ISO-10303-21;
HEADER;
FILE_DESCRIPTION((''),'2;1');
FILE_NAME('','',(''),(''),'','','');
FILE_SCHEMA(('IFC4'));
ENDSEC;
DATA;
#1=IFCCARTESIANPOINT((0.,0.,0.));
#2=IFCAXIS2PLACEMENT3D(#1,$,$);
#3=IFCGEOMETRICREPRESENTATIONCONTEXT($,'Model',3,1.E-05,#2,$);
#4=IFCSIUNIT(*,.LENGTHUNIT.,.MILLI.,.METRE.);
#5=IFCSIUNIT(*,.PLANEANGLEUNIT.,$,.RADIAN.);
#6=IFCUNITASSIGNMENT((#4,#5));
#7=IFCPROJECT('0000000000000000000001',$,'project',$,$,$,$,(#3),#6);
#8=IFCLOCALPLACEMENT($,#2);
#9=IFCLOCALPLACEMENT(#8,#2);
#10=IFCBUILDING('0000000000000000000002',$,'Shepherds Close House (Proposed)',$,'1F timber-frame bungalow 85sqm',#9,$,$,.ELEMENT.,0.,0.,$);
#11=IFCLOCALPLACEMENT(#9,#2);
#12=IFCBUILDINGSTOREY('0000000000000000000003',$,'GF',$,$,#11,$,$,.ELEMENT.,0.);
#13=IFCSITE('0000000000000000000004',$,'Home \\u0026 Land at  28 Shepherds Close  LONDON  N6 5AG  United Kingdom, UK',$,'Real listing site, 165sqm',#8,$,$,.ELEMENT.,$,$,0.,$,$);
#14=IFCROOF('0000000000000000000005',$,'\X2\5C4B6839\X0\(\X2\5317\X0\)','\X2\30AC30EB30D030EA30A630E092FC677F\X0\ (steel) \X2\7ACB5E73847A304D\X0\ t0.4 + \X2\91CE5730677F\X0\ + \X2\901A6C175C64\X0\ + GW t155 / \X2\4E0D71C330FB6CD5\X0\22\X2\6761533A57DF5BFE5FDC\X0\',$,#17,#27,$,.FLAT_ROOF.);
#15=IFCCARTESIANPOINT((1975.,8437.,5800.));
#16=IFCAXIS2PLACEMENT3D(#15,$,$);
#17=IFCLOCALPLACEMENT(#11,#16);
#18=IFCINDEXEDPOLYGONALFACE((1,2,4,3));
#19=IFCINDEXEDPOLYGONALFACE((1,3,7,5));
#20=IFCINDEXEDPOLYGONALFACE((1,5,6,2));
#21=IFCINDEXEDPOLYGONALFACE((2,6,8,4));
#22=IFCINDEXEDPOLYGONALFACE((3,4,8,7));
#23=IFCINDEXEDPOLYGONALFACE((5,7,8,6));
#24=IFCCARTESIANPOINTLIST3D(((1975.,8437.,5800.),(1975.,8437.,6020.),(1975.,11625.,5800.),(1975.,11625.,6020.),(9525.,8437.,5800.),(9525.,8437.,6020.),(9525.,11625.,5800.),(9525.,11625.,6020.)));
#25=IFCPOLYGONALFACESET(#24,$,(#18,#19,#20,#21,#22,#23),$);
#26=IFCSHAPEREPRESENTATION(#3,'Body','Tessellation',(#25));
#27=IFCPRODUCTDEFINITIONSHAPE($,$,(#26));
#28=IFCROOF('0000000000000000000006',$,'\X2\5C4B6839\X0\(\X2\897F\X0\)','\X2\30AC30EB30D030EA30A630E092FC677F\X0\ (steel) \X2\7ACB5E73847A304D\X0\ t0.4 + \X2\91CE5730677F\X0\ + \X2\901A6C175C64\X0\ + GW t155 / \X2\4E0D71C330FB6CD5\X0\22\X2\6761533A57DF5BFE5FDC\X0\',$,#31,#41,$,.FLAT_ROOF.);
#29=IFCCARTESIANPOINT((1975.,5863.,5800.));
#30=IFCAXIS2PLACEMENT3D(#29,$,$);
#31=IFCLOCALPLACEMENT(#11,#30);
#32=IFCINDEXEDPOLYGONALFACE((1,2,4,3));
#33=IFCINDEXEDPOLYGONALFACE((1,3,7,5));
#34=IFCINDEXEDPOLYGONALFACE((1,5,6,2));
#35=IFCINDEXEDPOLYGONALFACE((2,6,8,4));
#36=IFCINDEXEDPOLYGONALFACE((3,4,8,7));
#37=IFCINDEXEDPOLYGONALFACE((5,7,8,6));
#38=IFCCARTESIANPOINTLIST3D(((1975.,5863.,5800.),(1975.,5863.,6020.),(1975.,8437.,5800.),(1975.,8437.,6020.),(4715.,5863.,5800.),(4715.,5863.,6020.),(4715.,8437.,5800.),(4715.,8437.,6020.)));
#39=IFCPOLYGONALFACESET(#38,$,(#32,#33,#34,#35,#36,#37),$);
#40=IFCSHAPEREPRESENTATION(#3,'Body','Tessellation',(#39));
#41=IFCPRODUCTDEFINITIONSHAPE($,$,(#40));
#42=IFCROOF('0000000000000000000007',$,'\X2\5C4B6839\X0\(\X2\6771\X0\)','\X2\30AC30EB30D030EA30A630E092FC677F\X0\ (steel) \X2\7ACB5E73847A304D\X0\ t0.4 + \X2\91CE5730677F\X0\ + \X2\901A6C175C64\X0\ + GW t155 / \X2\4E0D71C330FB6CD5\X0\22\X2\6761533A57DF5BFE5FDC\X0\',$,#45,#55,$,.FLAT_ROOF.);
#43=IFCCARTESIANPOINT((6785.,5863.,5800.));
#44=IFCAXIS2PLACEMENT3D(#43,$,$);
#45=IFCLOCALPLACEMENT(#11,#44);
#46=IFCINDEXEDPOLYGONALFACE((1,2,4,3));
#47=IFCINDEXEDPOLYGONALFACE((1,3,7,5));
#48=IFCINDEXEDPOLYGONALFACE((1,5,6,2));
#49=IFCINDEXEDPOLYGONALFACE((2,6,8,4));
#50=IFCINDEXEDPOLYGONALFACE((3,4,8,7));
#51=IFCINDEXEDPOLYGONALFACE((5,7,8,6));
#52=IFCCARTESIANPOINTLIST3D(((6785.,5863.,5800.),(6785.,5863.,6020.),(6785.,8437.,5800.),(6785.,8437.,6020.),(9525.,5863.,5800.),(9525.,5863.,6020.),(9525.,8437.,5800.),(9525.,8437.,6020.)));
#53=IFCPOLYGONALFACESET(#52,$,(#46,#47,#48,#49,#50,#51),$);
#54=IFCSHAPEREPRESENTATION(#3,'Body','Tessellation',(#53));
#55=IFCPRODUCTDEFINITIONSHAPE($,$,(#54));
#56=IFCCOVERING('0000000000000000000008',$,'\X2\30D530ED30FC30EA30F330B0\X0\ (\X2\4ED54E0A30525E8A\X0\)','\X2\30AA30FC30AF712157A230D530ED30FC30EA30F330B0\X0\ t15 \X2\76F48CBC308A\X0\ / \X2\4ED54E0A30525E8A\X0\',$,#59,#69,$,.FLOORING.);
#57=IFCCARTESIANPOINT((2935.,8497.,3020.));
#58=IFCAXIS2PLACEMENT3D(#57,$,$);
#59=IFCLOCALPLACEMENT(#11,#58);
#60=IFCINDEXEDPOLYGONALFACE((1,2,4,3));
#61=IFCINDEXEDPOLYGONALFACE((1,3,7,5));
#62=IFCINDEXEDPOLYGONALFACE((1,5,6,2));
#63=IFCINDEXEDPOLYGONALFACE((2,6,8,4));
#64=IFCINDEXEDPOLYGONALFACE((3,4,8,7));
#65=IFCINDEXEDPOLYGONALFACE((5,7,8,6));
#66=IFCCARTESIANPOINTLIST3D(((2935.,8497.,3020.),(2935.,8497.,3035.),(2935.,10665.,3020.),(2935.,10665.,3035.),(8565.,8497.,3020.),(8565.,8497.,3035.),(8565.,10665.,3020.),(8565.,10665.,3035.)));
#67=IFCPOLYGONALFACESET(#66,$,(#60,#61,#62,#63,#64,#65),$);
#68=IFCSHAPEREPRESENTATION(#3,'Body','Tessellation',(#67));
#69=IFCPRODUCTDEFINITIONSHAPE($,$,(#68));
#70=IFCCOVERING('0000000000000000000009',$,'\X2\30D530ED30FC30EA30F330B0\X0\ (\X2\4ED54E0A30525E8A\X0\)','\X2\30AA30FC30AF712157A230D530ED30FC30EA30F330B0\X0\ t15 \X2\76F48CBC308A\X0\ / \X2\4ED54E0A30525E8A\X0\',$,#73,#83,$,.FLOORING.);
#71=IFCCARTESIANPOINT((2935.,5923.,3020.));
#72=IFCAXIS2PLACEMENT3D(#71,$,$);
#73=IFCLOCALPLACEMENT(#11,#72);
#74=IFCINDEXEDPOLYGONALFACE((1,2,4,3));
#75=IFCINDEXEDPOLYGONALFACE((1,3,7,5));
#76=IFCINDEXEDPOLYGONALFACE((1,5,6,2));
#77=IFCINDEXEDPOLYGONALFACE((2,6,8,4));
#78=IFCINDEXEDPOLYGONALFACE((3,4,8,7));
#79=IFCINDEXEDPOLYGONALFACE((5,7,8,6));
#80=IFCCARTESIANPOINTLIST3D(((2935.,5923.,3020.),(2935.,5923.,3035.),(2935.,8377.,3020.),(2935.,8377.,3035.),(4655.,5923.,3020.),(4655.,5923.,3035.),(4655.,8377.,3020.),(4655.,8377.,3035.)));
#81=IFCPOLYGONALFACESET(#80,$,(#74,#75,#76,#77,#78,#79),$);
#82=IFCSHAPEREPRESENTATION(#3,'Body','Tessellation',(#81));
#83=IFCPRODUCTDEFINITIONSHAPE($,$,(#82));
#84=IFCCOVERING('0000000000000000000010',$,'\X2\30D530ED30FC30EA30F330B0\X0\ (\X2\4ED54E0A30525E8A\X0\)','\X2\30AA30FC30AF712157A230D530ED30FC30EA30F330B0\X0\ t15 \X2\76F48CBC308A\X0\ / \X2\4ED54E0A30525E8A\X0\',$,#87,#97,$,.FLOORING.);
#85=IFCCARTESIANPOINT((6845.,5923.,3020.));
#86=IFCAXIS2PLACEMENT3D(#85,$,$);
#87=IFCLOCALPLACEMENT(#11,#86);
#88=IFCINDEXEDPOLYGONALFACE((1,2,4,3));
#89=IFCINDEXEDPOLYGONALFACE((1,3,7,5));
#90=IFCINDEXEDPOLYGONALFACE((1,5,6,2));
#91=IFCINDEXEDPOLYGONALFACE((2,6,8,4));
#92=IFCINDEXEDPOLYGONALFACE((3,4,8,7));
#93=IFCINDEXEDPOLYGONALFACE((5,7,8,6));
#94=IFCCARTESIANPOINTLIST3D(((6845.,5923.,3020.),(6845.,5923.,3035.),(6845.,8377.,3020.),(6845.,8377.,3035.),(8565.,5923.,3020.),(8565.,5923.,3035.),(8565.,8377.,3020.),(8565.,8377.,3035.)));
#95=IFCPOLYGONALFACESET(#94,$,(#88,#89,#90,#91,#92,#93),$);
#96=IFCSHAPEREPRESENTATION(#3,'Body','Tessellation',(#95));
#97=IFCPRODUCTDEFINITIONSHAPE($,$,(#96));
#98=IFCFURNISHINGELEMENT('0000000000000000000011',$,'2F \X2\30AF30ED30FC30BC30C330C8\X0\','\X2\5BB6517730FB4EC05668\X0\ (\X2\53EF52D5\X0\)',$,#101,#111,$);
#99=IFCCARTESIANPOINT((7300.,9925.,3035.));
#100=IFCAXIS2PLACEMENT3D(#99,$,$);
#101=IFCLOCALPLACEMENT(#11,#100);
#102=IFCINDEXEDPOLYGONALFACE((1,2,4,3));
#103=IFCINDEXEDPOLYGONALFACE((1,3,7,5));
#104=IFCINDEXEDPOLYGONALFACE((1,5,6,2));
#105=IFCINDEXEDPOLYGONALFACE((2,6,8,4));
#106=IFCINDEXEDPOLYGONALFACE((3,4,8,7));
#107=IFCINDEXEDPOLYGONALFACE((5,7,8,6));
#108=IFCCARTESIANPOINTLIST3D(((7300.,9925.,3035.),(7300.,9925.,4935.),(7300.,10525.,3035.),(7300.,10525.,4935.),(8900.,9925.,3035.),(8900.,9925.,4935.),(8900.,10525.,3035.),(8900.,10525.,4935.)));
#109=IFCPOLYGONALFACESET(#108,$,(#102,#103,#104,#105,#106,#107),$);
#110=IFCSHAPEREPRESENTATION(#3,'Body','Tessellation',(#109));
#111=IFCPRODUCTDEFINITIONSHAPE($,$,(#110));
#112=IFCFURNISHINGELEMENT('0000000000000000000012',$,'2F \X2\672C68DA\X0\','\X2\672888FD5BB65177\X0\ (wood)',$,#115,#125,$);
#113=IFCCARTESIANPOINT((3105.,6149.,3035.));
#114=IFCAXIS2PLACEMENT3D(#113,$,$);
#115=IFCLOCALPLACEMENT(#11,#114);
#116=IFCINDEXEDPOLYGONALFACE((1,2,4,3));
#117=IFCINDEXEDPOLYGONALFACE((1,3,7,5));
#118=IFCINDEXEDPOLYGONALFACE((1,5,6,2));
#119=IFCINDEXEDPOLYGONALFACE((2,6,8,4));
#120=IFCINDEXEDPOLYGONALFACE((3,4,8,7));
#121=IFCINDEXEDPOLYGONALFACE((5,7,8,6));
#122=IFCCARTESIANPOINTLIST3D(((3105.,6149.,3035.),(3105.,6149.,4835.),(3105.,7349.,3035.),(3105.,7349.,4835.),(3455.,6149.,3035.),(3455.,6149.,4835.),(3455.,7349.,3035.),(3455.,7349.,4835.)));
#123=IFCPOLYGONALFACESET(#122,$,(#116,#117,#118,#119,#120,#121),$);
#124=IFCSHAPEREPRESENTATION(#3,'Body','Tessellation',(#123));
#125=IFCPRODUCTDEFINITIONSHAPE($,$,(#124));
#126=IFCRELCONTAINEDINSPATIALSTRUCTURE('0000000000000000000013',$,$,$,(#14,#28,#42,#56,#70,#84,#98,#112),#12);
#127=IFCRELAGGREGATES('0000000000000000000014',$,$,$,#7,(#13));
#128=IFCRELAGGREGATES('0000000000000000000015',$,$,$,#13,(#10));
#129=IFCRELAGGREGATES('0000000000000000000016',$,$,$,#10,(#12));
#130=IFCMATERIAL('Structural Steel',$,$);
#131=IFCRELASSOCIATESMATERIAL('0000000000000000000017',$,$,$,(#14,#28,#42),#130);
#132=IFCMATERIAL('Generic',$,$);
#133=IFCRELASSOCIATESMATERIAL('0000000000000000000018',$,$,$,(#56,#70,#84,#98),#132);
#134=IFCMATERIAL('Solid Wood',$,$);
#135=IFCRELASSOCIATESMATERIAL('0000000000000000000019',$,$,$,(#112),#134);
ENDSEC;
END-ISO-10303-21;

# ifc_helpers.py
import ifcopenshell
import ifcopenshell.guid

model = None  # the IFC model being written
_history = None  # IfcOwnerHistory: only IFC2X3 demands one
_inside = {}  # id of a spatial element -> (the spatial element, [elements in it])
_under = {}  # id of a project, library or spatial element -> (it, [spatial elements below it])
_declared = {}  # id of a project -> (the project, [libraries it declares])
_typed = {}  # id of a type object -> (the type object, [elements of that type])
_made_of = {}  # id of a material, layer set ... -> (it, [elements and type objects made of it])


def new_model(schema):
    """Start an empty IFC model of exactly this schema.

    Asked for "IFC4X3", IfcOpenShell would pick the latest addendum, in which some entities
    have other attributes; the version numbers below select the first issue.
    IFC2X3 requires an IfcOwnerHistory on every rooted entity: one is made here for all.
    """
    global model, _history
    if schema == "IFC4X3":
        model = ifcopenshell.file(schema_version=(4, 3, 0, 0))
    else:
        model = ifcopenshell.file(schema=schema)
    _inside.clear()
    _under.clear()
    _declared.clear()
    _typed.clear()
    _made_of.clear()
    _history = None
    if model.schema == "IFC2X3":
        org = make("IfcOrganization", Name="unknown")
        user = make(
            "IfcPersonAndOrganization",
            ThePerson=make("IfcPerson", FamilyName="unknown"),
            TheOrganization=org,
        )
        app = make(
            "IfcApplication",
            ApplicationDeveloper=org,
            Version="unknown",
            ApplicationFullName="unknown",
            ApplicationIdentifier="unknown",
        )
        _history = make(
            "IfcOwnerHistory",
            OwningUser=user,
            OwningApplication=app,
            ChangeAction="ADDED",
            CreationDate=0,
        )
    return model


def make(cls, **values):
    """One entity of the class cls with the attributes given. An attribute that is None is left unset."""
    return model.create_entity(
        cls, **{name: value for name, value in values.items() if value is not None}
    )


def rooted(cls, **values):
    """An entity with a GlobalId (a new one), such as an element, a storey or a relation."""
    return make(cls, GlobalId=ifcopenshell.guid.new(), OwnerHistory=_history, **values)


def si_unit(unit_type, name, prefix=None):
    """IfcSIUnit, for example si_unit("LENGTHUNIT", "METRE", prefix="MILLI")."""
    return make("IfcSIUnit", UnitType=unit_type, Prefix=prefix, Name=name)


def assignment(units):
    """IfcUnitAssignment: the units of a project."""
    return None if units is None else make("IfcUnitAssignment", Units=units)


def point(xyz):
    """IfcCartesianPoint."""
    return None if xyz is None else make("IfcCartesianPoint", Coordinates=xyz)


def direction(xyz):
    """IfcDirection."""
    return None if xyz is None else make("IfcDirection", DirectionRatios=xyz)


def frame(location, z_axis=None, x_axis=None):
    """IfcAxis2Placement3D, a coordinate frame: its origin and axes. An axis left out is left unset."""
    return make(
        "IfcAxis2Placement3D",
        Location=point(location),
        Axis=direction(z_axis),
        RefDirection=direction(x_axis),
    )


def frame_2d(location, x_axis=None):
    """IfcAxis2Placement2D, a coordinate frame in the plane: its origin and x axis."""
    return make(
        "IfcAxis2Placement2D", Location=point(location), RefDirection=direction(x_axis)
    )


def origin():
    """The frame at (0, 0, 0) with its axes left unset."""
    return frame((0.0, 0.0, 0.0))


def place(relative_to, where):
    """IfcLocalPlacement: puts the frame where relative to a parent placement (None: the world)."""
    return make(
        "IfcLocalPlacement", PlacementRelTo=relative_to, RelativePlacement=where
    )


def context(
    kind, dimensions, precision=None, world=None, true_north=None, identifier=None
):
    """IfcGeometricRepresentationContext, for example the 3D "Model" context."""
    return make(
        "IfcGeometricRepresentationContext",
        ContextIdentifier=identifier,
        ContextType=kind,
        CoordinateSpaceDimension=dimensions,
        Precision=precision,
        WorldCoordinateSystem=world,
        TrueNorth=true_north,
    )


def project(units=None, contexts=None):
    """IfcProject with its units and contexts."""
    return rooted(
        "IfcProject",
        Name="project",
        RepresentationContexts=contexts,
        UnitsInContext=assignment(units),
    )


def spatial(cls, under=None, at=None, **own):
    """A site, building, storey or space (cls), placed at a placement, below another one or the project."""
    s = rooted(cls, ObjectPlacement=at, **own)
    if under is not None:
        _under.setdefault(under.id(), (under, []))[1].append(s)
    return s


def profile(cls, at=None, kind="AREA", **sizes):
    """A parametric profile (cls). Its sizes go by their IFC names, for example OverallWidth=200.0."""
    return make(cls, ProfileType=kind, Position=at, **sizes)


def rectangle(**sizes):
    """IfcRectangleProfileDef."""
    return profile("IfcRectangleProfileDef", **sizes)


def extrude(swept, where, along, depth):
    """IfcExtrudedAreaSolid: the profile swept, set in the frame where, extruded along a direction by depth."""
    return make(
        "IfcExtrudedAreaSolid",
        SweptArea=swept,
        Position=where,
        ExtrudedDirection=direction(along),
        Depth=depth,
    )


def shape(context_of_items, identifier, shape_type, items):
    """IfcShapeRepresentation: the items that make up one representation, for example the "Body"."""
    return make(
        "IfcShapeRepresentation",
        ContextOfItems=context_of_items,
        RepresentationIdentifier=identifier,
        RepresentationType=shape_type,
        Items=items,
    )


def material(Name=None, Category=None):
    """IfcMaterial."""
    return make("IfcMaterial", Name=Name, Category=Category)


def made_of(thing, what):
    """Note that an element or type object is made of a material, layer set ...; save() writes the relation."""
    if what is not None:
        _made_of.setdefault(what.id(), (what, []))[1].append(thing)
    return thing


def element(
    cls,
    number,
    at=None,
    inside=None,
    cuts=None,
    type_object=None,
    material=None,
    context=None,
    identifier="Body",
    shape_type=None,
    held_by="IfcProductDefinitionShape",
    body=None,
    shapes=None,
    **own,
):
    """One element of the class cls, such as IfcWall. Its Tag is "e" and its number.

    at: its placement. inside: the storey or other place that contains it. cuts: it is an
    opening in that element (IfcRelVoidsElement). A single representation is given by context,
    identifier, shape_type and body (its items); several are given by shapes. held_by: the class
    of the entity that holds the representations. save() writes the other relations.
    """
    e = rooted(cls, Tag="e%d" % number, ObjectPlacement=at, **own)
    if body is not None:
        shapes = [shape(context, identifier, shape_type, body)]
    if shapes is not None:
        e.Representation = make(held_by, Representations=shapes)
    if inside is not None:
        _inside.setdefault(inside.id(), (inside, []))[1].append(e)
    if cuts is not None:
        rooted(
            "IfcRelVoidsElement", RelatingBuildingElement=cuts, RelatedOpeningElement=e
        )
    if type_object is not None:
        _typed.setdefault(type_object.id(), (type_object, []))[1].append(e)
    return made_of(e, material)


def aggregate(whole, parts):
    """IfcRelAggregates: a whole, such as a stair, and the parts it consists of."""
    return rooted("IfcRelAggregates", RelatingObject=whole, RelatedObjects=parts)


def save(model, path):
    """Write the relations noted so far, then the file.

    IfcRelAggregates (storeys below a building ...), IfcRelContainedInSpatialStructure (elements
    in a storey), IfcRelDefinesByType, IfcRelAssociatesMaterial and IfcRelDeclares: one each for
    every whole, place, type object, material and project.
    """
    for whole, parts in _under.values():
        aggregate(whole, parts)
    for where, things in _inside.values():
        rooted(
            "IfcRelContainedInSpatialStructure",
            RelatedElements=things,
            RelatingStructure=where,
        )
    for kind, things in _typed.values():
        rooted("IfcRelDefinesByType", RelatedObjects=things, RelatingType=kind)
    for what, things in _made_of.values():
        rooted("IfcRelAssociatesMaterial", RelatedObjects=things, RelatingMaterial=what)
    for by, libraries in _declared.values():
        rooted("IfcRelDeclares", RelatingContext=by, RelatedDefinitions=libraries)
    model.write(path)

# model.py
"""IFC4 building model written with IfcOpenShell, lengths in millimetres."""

from ifc_helpers import new_model, si_unit, frame, frame_2d, origin, place, context, project, spatial, rectangle, extrude, material, element, save


model = new_model("IFC4")

# Units and contexts
model_context = context("Model", 3, precision=1e-05, world=origin())
ifc_project = project(units=[si_unit("LENGTHUNIT", "METRE", prefix="MILLI"), si_unit("PLANEANGLEUNIT", "RADIAN")], contexts=[model_context])

# Site, building, storey
site_placement = place(None, origin())
site = spatial("IfcSite", under=ifc_project, at=site_placement, Name="Home \\u0026 Land at  28 Shepherds Close  LONDON  N6 5AG  United Kingdom, UK", ObjectType="Real listing site, 165sqm", CompositionType="ELEMENT", RefElevation=0.0)
building_placement = place(site_placement, origin())
building = spatial("IfcBuilding", under=site, at=building_placement, Name="Shepherds Close House (Proposed)", ObjectType="1F timber-frame bungalow 85sqm", CompositionType="ELEMENT", ElevationOfRefHeight=0.0, ElevationOfTerrain=0.0)
storey_placement = place(building_placement, origin())
storey = spatial("IfcBuildingStorey", under=building, at=storey_placement, Name="GF", CompositionType="ELEMENT", Elevation=0.0)

# Shared definitions
ifc_material_1 = material(Name="Solid Wood")

# Shared definitions
ifc_material_2 = material(Name="Generic")

# Roofs
ifc_material_3 = material(Name="Structural Steel")
for number, where, name in (
    (1, (1975.0, 8437.0, 5800.0), "屋根(北)"),
):
    element("IfcRoof", number, at=place(storey_placement, frame(where)), inside=storey, material=ifc_material_3, Name=name, Description="ガルバリウム鋼板 (steel) 立平葺き t0.4 + 野地板 + 通気層 + GW t155 / 不燃・法22条区域対応", PredefinedType="FLAT_ROOF", context=model_context, shape_type="SweptSolid", body=[
        extrude(rectangle(XDim=7550.0, YDim=3188.0, at=frame_2d((3775.0, 1594.0))), frame((1975.0, 8437.0, 5800.0)), (0.0, 0.0, 1.0), 220.0),
    ])
roof_1_placement = place(storey_placement, frame((1975.0, 5863.0, 5800.0)))
element("IfcRoof", 2, at=roof_1_placement, inside=storey, material=ifc_material_3, Name="屋根(西)", Description="ガルバリウム鋼板 (steel) 立平葺き t0.4 + 野地板 + 通気層 + GW t155 / 不燃・法22条区域対応", PredefinedType="FLAT_ROOF", context=model_context, shape_type="SweptSolid", body=[
    extrude(rectangle(XDim=2740.0, YDim=2574.0, at=frame_2d((1370.0, 1287.0))), frame((1975.0, 5863.0, 5800.0)), (0.0, 0.0, 1.0), 220.0),
])
roof_2_placement = place(storey_placement, frame((6785.0, 5863.0, 5800.0)))
element("IfcRoof", 3, at=roof_2_placement, inside=storey, material=ifc_material_3, Name="屋根(東)", Description="ガルバリウム鋼板 (steel) 立平葺き t0.4 + 野地板 + 通気層 + GW t155 / 不燃・法22条区域対応", PredefinedType="FLAT_ROOF", context=model_context, shape_type="SweptSolid", body=[
    extrude(rectangle(XDim=2740.0, YDim=2574.0, at=frame_2d((1370.0, 1287.0))), frame((6785.0, 5863.0, 5800.0)), (0.0, 0.0, 1.0), 220.0),
])

# Coverings
covering_1_placement = place(storey_placement, frame((2935.0, 8497.0, 3020.0)))
element("IfcCovering", 4, at=covering_1_placement, inside=storey, material=ifc_material_2, Name="フローリング (仕上げ床)", Description="オーク無垢フローリング t15 直貼り / 仕上げ床", PredefinedType="FLOORING", context=model_context, shape_type="SweptSolid", body=[
    extrude(rectangle(XDim=5630.0, YDim=2168.0, at=frame_2d((2815.0, 1084.0))), frame((2935.0, 8497.0, 3020.0)), (0.0, 0.0, 1.0), 15.0),
])
covering_2_placement = place(storey_placement, frame((2935.0, 5923.0, 3020.0)))
element("IfcCovering", 5, at=covering_2_placement, inside=storey, material=ifc_material_2, Name="フローリング (仕上げ床)", Description="オーク無垢フローリング t15 直貼り / 仕上げ床", PredefinedType="FLOORING", context=model_context, shape_type="SweptSolid", body=[
    extrude(rectangle(XDim=1720.0, YDim=2454.0, at=frame_2d((860.0, 1227.0))), frame((2935.0, 5923.0, 3020.0)), (0.0, 0.0, 1.0), 15.0),
])
covering_3_placement = place(storey_placement, frame((6845.0, 5923.0, 3020.0)))
element("IfcCovering", 6, at=covering_3_placement, inside=storey, material=ifc_material_2, Name="フローリング (仕上げ床)", Description="オーク無垢フローリング t15 直貼り / 仕上げ床", PredefinedType="FLOORING", context=model_context, shape_type="SweptSolid", body=[
    extrude(rectangle(XDim=1720.0, YDim=2454.0, at=frame_2d((860.0, 1227.0))), frame((6845.0, 5923.0, 3020.0)), (0.0, 0.0, 1.0), 15.0),
])

# Furnishing elements
furnishing_1_placement = place(storey_placement, frame((7300.0, 9925.0, 3035.0)))
element("IfcFurnishingElement", 7, at=furnishing_1_placement, inside=storey, material=ifc_material_2, Name="2F クローゼット", Description="家具・什器 (可動)", context=model_context, shape_type="SweptSolid", body=[
    extrude(rectangle(XDim=1600.0, YDim=600.0, at=frame_2d((800.0, 300.0))), frame((7300.0, 9925.0, 3035.0)), (0.0, 0.0, 1.0), 1900.0),
])
furnishing_2_placement = place(storey_placement, frame((3105.0, 6149.0, 3035.0)))
element("IfcFurnishingElement", 8, at=furnishing_2_placement, inside=storey, material=ifc_material_1, Name="2F 本棚", Description="木製家具 (wood)", context=model_context, shape_type="SweptSolid", body=[
    extrude(rectangle(XDim=350.0, YDim=1200.0, at=frame_2d((175.0, 600.0))), frame((3105.0, 6149.0, 3035.0)), (0.0, 0.0, 1.0), 1800.0),
])

save(model, "model.ifc")
